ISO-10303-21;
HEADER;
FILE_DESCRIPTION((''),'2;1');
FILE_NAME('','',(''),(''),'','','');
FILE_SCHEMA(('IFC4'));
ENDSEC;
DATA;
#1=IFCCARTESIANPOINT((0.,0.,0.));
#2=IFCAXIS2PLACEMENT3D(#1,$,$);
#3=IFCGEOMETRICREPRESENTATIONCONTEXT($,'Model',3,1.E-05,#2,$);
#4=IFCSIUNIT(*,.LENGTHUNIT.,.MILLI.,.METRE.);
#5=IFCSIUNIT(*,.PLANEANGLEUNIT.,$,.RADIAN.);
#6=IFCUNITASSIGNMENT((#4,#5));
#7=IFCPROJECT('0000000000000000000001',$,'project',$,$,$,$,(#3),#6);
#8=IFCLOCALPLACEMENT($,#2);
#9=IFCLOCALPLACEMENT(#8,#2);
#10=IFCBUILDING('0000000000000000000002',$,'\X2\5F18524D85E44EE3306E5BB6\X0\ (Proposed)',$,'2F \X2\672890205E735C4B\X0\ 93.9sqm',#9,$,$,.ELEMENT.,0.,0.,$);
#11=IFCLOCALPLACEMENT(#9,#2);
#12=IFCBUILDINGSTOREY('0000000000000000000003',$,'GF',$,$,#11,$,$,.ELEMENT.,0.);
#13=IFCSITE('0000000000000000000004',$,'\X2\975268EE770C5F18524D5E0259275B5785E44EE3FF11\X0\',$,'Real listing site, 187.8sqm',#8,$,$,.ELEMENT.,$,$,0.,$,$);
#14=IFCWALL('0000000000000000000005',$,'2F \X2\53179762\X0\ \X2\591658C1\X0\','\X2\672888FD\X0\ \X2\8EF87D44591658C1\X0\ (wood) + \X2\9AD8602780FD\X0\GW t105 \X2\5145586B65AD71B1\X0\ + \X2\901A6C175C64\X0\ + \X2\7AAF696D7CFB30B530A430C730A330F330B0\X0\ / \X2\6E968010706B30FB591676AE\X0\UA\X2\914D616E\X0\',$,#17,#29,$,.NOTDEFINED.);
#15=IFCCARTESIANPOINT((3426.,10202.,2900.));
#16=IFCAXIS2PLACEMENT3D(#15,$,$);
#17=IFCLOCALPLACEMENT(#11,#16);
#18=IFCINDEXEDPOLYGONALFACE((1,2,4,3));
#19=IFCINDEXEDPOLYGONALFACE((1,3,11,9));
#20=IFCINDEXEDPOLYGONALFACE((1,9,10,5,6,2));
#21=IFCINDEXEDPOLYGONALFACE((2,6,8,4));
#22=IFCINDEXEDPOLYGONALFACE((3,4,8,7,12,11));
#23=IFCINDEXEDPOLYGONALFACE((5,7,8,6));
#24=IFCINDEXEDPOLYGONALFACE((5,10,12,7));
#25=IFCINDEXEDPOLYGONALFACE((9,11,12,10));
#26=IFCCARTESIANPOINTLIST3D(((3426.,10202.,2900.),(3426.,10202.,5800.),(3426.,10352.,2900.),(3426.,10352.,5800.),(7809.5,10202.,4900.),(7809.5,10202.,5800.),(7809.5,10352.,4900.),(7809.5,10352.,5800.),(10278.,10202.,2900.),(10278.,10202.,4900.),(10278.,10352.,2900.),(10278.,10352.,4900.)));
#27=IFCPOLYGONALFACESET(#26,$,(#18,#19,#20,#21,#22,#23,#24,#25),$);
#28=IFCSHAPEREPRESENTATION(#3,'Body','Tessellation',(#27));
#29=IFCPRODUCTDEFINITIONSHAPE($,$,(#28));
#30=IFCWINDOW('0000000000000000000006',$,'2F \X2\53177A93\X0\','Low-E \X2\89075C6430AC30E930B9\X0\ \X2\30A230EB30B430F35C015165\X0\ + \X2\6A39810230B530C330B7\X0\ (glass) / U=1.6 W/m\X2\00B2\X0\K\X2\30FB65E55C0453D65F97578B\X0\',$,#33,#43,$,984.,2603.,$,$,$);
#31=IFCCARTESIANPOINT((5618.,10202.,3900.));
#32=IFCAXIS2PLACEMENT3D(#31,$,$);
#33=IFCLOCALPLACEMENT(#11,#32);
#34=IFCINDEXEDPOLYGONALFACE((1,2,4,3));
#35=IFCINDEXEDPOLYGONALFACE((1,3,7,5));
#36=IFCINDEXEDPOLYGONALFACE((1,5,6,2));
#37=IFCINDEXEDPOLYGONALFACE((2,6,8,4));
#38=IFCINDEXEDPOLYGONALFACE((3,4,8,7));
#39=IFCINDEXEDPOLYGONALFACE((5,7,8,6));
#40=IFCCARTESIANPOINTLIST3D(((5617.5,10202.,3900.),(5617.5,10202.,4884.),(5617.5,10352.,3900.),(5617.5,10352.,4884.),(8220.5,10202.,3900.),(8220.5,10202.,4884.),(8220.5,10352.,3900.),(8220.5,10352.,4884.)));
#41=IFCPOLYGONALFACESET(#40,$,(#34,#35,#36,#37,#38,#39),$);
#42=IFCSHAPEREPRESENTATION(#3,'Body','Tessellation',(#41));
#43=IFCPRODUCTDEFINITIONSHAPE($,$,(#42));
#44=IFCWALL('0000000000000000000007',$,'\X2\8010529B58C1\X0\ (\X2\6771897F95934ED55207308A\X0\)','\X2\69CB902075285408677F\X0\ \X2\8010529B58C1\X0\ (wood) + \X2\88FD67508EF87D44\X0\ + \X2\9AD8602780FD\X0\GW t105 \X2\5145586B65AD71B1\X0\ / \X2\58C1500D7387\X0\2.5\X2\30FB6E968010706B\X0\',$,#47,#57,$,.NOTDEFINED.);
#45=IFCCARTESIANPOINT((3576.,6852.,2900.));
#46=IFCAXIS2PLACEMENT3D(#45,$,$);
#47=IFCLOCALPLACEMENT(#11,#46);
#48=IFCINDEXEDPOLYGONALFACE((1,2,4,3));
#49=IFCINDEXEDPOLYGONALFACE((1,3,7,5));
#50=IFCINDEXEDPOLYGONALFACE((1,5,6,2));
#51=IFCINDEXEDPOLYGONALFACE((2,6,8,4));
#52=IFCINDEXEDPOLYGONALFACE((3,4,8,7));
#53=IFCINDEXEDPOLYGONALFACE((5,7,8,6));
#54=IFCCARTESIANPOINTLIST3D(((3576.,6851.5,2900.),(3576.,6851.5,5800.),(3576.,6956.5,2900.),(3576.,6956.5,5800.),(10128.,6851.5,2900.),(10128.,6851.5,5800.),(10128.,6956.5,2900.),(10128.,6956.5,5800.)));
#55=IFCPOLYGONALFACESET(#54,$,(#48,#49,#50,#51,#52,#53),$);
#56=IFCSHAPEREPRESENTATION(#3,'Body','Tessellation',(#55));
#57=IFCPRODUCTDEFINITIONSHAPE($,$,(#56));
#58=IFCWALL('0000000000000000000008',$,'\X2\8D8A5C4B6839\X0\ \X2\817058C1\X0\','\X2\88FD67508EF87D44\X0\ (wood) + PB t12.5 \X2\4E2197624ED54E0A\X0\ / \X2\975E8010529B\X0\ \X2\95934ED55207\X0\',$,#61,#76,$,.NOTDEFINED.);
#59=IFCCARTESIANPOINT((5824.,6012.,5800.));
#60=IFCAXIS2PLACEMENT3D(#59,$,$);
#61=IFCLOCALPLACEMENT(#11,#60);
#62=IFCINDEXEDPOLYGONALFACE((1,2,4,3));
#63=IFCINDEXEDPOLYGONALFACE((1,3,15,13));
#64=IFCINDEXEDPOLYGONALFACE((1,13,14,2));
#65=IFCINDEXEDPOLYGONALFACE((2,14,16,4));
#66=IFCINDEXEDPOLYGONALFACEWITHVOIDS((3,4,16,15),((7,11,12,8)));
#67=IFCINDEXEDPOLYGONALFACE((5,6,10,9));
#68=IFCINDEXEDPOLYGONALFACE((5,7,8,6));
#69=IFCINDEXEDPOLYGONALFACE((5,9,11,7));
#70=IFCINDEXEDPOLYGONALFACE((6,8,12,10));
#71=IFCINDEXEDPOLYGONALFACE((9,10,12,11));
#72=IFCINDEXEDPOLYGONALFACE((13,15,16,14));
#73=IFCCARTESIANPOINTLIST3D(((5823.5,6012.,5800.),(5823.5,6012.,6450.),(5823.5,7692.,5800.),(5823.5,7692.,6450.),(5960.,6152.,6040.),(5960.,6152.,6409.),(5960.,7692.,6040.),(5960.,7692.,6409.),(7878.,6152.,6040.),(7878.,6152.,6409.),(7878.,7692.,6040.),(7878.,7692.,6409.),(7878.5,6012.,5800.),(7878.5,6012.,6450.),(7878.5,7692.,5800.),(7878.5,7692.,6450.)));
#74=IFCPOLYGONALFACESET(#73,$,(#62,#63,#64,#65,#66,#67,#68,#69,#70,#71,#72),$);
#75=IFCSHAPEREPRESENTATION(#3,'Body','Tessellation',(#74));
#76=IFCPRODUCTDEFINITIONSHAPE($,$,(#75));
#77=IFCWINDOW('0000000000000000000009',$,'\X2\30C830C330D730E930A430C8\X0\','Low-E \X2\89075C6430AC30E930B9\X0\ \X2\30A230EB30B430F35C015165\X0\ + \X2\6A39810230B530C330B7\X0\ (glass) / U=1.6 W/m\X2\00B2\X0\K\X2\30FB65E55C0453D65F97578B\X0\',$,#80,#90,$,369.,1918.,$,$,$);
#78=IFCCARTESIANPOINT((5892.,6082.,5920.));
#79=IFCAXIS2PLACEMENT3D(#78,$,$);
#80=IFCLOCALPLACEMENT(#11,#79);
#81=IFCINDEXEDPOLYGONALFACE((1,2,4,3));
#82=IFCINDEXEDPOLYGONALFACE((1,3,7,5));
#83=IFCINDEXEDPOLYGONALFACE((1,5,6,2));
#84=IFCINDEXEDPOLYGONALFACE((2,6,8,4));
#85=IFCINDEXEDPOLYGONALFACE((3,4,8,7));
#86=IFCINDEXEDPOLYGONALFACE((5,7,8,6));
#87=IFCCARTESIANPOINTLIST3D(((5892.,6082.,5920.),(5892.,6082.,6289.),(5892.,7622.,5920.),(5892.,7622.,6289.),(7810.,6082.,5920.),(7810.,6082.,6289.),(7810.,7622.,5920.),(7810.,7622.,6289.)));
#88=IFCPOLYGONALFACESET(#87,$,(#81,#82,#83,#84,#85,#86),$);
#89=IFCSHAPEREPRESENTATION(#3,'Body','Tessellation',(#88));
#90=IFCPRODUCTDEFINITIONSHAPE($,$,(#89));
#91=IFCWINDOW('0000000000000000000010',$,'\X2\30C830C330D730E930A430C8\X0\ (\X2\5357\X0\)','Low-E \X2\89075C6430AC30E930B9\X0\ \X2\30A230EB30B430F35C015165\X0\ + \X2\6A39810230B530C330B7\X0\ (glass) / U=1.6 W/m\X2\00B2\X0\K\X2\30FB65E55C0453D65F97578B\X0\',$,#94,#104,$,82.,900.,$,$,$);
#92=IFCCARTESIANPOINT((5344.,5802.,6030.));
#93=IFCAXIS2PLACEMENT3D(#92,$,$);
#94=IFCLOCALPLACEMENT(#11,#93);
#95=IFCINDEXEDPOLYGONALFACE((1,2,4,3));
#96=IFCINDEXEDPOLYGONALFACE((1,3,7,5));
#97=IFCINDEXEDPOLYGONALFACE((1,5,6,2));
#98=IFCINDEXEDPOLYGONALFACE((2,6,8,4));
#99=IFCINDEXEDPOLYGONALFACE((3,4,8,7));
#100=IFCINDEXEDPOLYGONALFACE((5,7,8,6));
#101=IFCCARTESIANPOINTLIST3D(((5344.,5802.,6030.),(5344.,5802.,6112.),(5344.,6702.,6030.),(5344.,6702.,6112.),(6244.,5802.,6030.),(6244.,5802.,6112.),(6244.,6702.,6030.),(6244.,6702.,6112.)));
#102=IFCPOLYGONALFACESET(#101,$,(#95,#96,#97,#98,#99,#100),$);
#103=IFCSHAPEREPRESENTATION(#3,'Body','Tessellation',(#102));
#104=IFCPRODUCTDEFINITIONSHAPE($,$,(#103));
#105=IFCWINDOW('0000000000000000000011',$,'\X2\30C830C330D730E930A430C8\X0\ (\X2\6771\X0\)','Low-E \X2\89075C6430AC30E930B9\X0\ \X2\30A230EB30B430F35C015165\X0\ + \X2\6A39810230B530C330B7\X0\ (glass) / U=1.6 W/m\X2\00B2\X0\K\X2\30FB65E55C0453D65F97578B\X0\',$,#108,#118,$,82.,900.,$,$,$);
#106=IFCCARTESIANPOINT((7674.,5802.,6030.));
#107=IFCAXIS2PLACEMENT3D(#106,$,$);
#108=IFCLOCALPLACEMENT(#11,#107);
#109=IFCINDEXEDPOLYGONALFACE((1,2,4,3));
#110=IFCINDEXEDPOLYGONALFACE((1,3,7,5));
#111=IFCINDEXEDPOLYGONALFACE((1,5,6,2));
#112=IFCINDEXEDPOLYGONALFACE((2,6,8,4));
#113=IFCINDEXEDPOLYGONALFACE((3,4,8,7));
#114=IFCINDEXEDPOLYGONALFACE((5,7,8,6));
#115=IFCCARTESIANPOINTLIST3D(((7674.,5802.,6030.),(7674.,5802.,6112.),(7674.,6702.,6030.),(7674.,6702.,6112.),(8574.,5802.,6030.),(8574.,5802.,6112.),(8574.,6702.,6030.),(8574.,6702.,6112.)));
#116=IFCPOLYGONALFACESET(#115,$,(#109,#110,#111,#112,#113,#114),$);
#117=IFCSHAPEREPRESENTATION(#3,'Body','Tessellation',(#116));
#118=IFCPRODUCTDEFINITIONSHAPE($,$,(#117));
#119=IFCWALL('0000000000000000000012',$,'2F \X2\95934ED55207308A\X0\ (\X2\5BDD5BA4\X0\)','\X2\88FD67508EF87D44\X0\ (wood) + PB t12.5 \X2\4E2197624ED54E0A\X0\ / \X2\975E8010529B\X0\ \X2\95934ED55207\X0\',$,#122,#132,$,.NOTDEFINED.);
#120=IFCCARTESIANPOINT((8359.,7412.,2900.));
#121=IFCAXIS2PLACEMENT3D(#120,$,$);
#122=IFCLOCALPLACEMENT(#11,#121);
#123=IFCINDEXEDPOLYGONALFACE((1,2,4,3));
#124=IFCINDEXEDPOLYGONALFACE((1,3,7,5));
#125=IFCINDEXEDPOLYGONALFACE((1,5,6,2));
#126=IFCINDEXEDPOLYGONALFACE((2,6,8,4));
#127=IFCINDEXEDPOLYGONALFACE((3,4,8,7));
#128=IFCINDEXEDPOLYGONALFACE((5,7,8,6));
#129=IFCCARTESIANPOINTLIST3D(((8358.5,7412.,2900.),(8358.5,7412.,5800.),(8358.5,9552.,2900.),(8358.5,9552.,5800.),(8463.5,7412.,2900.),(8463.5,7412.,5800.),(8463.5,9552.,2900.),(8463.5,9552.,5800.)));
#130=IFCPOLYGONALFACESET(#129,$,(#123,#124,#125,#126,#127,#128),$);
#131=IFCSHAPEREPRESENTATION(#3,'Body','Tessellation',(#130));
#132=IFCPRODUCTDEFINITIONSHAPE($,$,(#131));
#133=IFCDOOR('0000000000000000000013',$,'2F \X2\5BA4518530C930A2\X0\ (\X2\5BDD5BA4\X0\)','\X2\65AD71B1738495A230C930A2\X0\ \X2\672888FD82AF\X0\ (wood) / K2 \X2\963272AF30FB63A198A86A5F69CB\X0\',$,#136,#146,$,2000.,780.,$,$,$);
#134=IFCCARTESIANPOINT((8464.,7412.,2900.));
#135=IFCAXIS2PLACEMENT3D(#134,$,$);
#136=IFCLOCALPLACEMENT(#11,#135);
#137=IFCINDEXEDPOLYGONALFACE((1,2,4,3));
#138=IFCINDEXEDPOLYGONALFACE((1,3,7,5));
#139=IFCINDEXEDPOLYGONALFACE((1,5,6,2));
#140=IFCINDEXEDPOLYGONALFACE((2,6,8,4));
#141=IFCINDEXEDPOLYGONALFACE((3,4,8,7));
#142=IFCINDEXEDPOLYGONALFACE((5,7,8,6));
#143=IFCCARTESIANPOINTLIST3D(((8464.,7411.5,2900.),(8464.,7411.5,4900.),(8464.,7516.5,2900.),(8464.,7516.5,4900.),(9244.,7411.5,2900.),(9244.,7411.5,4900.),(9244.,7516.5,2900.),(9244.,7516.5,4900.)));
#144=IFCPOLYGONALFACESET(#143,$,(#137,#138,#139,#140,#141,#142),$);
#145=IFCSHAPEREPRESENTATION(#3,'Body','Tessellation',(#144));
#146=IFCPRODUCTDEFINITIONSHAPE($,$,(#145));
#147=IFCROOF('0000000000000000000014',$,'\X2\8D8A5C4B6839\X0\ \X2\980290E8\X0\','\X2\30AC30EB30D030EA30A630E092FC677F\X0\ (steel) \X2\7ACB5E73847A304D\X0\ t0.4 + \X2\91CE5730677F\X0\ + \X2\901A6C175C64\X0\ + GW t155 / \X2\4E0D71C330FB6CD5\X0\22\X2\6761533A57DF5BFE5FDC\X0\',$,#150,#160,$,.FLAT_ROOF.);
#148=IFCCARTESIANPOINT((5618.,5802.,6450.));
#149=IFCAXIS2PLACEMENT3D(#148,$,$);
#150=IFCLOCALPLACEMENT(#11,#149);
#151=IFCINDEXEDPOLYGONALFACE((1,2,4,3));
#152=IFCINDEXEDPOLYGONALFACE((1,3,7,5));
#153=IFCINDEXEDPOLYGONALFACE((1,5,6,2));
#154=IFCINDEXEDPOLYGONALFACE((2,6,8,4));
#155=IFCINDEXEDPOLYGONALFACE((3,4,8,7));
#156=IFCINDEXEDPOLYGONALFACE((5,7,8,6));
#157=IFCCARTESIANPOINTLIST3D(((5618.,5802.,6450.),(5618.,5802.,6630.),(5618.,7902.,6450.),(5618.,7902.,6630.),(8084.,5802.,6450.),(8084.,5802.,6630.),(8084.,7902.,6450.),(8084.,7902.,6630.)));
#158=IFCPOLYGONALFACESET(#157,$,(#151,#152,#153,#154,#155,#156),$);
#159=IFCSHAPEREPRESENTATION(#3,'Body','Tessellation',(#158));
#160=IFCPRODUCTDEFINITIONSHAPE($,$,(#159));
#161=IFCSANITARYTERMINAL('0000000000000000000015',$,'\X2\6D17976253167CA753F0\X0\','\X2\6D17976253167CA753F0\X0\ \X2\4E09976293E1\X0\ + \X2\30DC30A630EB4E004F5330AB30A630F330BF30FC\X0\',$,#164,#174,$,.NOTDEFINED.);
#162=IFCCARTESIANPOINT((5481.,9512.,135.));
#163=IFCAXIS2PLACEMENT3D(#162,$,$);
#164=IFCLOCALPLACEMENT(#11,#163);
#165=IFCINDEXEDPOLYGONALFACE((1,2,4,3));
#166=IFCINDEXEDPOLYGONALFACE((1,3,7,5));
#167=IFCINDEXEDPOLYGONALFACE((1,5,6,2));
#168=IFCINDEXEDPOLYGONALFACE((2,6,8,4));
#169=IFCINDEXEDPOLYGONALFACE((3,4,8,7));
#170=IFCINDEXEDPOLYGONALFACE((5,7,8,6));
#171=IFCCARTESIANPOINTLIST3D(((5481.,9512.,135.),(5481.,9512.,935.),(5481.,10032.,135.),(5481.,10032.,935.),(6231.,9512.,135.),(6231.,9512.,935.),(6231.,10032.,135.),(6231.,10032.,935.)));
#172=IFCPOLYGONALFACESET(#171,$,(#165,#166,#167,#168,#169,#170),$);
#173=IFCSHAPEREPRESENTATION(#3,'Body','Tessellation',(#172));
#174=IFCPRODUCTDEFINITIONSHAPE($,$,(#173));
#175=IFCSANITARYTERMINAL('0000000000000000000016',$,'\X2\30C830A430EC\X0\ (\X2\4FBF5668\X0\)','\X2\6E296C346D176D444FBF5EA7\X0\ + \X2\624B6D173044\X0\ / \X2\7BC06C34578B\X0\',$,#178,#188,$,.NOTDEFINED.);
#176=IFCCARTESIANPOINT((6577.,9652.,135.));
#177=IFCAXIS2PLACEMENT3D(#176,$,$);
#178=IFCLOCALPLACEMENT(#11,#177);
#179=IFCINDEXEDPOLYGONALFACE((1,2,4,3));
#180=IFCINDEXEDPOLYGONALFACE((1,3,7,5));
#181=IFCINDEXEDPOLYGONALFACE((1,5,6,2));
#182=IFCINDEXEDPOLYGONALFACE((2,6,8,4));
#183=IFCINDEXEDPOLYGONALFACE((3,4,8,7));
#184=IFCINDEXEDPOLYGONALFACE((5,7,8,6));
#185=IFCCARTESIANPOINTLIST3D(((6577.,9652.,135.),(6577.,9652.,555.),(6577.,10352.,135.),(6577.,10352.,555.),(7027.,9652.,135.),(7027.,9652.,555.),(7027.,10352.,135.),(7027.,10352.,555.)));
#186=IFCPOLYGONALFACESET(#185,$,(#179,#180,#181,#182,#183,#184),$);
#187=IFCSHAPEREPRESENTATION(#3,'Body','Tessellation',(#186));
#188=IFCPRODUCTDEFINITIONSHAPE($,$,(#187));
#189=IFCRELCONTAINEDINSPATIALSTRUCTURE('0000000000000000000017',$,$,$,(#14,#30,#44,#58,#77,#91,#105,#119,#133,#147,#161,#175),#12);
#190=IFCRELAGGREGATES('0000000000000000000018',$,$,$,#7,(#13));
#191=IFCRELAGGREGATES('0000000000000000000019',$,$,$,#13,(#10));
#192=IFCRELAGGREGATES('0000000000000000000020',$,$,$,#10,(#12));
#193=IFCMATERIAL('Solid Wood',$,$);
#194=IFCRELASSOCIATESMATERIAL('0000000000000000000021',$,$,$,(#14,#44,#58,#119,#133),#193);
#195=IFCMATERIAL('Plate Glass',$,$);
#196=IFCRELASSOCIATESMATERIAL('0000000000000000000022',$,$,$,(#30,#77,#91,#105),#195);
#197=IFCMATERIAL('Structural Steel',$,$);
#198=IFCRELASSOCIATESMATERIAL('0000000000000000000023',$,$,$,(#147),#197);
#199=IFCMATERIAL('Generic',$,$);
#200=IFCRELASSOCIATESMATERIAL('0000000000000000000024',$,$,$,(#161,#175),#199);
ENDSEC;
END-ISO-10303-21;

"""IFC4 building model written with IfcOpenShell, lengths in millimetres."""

from ifc_helpers import new_model, si_unit, frame, frame_2d, origin, place, context, project, spatial, rectangle, extrude, material, element, fill, save


model = new_model("IFC4")

# Units and contexts
model_context = context("Model", 3, precision=1e-05, world=origin())
ifc_project = project(units=[si_unit("LENGTHUNIT", "METRE", prefix="MILLI"), si_unit("PLANEANGLEUNIT", "RADIAN")], contexts=[model_context])

# Site, building, storey
site_placement = place(None, origin())
site = spatial("IfcSite", under=ifc_project, at=site_placement, Name="青森県弘前市大字藤代１", ObjectType="Real listing site, 187.8sqm", CompositionType="ELEMENT", RefElevation=0.0)
building_placement = place(site_placement, origin())
building = spatial("IfcBuilding", under=site, at=building_placement, Name="弘前藤代の家 (Proposed)", ObjectType="2F 木造平屋 93.9sqm", CompositionType="ELEMENT", ElevationOfRefHeight=0.0, ElevationOfTerrain=0.0)
storey_placement = place(building_placement, origin())
storey = spatial("IfcBuildingStorey", under=building, at=storey_placement, Name="GF", CompositionType="ELEMENT", Elevation=0.0)

# Wall, opening, window
ifc_material_1 = material(Name="Solid Wood")
wall_1_placement = place(storey_placement, frame((3426.0, 10202.0, 2900.0)))
wall_1 = element("IfcWall", 1, at=wall_1_placement, inside=storey, material=ifc_material_1, Name="2F 北面 外壁", Description="木製 軸組外壁 (wood) + 高性能GW t105 充填断熱 + 通気層 + 窯業系サイディング / 準耐火・外皮UA配慮", PredefinedType="NOTDEFINED", context=model_context, shape_type="SweptSolid", body=[
    extrude(rectangle(XDim=6852.0, YDim=150.0, at=frame_2d((3426.0, 75.0))), frame((3426.0, 10202.0, 2900.0)), (0.0, 0.0, 1.0), 2900.0),
])
opening_1_placement = place(storey_placement, frame((5618.0, 10202.0, 3900.0)))
opening_1 = element("IfcOpeningElement", 2, at=opening_1_placement, cuts=wall_1, PredefinedType="NOTDEFINED", context=model_context, shape_type="SweptSolid", body=[
    extrude(rectangle(XDim=2603.0, YDim=150.0, at=frame_2d((1301.0, 75.0))), frame((5618.0, 10202.0, 3900.0)), (0.0, 0.0, 1.0), 984.0),
])
ifc_material_2 = material(Name="Plate Glass")
window_1_placement = place(storey_placement, frame((5618.0, 10202.0, 3900.0)))
window_1 = element("IfcWindow", 3, at=window_1_placement, inside=storey, material=ifc_material_2, Name="2F 北窓", Description="Low-E 複層ガラス アルゴン封入 + 樹脂サッシ (glass) / U=1.6 W/m²K・日射取得型", OverallHeight=984.0, OverallWidth=2603.0, context=model_context, shape_type="SweptSolid", body=[
    extrude(rectangle(XDim=2603.0, YDim=150.0, at=frame_2d((1301.0, 75.0))), frame((5618.0, 10202.0, 3900.0)), (0.0, 0.0, 1.0), 984.0),
])
fill(opening_1, window_1)

# Wall
wall_2_placement = place(storey_placement, frame((3576.0, 6852.0, 2900.0)))
element("IfcWall", 4, at=wall_2_placement, inside=storey, material=ifc_material_1, Name="耐力壁 (東西間仕切り)", Description="構造用合板 耐力壁 (wood) + 製材軸組 + 高性能GW t105 充填断熱 / 壁倍率2.5・準耐火", PredefinedType="NOTDEFINED", context=model_context, shape_type="SweptSolid", body=[
    extrude(rectangle(XDim=6552.0, YDim=105.0, at=frame_2d((3276.0, 52.0))), frame((3576.0, 6852.0, 2900.0)), (0.0, 0.0, 1.0), 2900.0),
])

# Wall, openings, windows
wall_3_placement = place(storey_placement, frame((5824.0, 6012.0, 5800.0)))
wall_3 = element("IfcWall", 5, at=wall_3_placement, inside=storey, material=ifc_material_1, Name="越屋根 腰壁", Description="製材軸組 (wood) + PB t12.5 両面仕上 / 非耐力 間仕切", PredefinedType="NOTDEFINED", context=model_context, shape_type="SweptSolid", body=[
    extrude(rectangle(XDim=2055.0, YDim=1680.0, at=frame_2d((1027.0, 840.0))), frame((5824.0, 6012.0, 5800.0)), (0.0, 0.0, 1.0), 650.0),
])
opening_2_placement = place(storey_placement, frame((5892.0, 6082.0, 5920.0)))
opening_2 = element("IfcOpeningElement", 6, at=opening_2_placement, cuts=wall_3, PredefinedType="NOTDEFINED", context=model_context, shape_type="SweptSolid", body=[
    extrude(rectangle(XDim=1918.0, YDim=1540.0, at=frame_2d((959.0, 770.0))), frame((5892.0, 6082.0, 5920.0)), (0.0, 0.0, 1.0), 369.0),
])
opening_3_placement = place(storey_placement, frame((5344.0, 5802.0, 6030.0)))
opening_3 = element("IfcOpeningElement", 7, at=opening_3_placement, cuts=wall_3, PredefinedType="NOTDEFINED", context=model_context, shape_type="SweptSolid", body=[
    extrude(rectangle(XDim=900.0, YDim=900.0, at=frame_2d((450.0, 450.0))), frame((5344.0, 5802.0, 6030.0)), (0.0, 0.0, 1.0), 82.0),
])
opening_4_placement = place(storey_placement, frame((7674.0, 5802.0, 6030.0)))
opening_4 = element("IfcOpeningElement", 8, at=opening_4_placement, cuts=wall_3, PredefinedType="NOTDEFINED", context=model_context, shape_type="SweptSolid", body=[
    extrude(rectangle(XDim=900.0, YDim=900.0, at=frame_2d((450.0, 450.0))), frame((7674.0, 5802.0, 6030.0)), (0.0, 0.0, 1.0), 82.0),
])
window_2_placement = place(storey_placement, frame((5892.0, 6082.0, 5920.0)))
window_2 = element("IfcWindow", 9, at=window_2_placement, inside=storey, material=ifc_material_2, Name="トップライト", Description="Low-E 複層ガラス アルゴン封入 + 樹脂サッシ (glass) / U=1.6 W/m²K・日射取得型", OverallHeight=369.0, OverallWidth=1918.0, context=model_context, shape_type="SweptSolid", body=[
    extrude(rectangle(XDim=1918.0, YDim=1540.0, at=frame_2d((959.0, 770.0))), frame((5892.0, 6082.0, 5920.0)), (0.0, 0.0, 1.0), 369.0),
])
fill(opening_2, window_2)
window_3_placement = place(storey_placement, frame((5344.0, 5802.0, 6030.0)))
window_3 = element("IfcWindow", 10, at=window_3_placement, inside=storey, material=ifc_material_2, Name="トップライト (南)", Description="Low-E 複層ガラス アルゴン封入 + 樹脂サッシ (glass) / U=1.6 W/m²K・日射取得型", OverallHeight=82.0, OverallWidth=900.0, context=model_context, shape_type="SweptSolid", body=[
    extrude(rectangle(XDim=900.0, YDim=900.0, at=frame_2d((450.0, 450.0))), frame((5344.0, 5802.0, 6030.0)), (0.0, 0.0, 1.0), 82.0),
])
fill(opening_3, window_3)
window_4_placement = place(storey_placement, frame((7674.0, 5802.0, 6030.0)))
window_4 = element("IfcWindow", 11, at=window_4_placement, inside=storey, material=ifc_material_2, Name="トップライト (東)", Description="Low-E 複層ガラス アルゴン封入 + 樹脂サッシ (glass) / U=1.6 W/m²K・日射取得型", OverallHeight=82.0, OverallWidth=900.0, context=model_context, shape_type="SweptSolid", body=[
    extrude(rectangle(XDim=900.0, YDim=900.0, at=frame_2d((450.0, 450.0))), frame((7674.0, 5802.0, 6030.0)), (0.0, 0.0, 1.0), 82.0),
])
fill(opening_4, window_4)

# Wall
wall_4_placement = place(storey_placement, frame((8359.0, 7412.0, 2900.0)))
element("IfcWall", 12, at=wall_4_placement, inside=storey, material=ifc_material_1, Name="2F 間仕切り (寝室)", Description="製材軸組 (wood) + PB t12.5 両面仕上 / 非耐力 間仕切", PredefinedType="NOTDEFINED", context=model_context, shape_type="SweptSolid", body=[
    extrude(rectangle(XDim=105.0, YDim=2140.0, at=frame_2d((52.0, 1070.0))), frame((8359.0, 7412.0, 2900.0)), (0.0, 0.0, 1.0), 2900.0),
])

# Door
door_placement = place(storey_placement, frame((8464.0, 7412.0, 2900.0)))
element("IfcDoor", 13, at=door_placement, inside=storey, material=ifc_material_1, Name="2F 室内ドア (寝室)", Description="断熱玄関ドア 木製芯 (wood) / K2 防犯・採風機構", OverallHeight=2000.0, OverallWidth=780.0, context=model_context, shape_type="SweptSolid", body=[
    extrude(rectangle(XDim=780.0, YDim=105.0, at=frame_2d((390.0, 52.0))), frame((8464.0, 7412.0, 2900.0)), (0.0, 0.0, 1.0), 2000.0),
])

# Roof
ifc_material_3 = material(Name="Structural Steel")
roof_placement = place(storey_placement, frame((5618.0, 5802.0, 6450.0)))
element("IfcRoof", 14, at=roof_placement, inside=storey, material=ifc_material_3, Name="越屋根 頂部", Description="ガルバリウム鋼板 (steel) 立平葺き t0.4 + 野地板 + 通気層 + GW t155 / 不燃・法22条区域対応", PredefinedType="FLAT_ROOF", context=model_context, shape_type="SweptSolid", body=[
    extrude(rectangle(XDim=2466.0, YDim=2100.0, at=frame_2d((1233.0, 1050.0))), frame((5618.0, 5802.0, 6450.0)), (0.0, 0.0, 1.0), 180.0),
])

# Sanitary terminals
ifc_material_4 = material(Name="Generic")
sanitary_terminal_1_placement = place(storey_placement, frame((5481.0, 9512.0, 135.0)))
element("IfcSanitaryTerminal", 15, at=sanitary_terminal_1_placement, inside=storey, material=ifc_material_4, Name="洗面化粧台", Description="洗面化粧台 三面鏡 + ボウル一体カウンター", PredefinedType="NOTDEFINED", context=model_context, shape_type="SweptSolid", body=[
    extrude(rectangle(XDim=750.0, YDim=520.0, at=frame_2d((375.0, 260.0))), frame((5481.0, 9512.0, 135.0)), (0.0, 0.0, 1.0), 800.0),
])
sanitary_terminal_2_placement = place(storey_placement, frame((6577.0, 9652.0, 135.0)))
element("IfcSanitaryTerminal", 16, at=sanitary_terminal_2_placement, inside=storey, material=ifc_material_4, Name="トイレ (便器)", Description="温水洗浄便座 + 手洗い / 節水型", PredefinedType="NOTDEFINED", context=model_context, shape_type="SweptSolid", body=[
    extrude(rectangle(XDim=450.0, YDim=700.0, at=frame_2d((225.0, 350.0))), frame((6577.0, 9652.0, 135.0)), (0.0, 0.0, 1.0), 420.0),
])

save(model, "model.ifc")
